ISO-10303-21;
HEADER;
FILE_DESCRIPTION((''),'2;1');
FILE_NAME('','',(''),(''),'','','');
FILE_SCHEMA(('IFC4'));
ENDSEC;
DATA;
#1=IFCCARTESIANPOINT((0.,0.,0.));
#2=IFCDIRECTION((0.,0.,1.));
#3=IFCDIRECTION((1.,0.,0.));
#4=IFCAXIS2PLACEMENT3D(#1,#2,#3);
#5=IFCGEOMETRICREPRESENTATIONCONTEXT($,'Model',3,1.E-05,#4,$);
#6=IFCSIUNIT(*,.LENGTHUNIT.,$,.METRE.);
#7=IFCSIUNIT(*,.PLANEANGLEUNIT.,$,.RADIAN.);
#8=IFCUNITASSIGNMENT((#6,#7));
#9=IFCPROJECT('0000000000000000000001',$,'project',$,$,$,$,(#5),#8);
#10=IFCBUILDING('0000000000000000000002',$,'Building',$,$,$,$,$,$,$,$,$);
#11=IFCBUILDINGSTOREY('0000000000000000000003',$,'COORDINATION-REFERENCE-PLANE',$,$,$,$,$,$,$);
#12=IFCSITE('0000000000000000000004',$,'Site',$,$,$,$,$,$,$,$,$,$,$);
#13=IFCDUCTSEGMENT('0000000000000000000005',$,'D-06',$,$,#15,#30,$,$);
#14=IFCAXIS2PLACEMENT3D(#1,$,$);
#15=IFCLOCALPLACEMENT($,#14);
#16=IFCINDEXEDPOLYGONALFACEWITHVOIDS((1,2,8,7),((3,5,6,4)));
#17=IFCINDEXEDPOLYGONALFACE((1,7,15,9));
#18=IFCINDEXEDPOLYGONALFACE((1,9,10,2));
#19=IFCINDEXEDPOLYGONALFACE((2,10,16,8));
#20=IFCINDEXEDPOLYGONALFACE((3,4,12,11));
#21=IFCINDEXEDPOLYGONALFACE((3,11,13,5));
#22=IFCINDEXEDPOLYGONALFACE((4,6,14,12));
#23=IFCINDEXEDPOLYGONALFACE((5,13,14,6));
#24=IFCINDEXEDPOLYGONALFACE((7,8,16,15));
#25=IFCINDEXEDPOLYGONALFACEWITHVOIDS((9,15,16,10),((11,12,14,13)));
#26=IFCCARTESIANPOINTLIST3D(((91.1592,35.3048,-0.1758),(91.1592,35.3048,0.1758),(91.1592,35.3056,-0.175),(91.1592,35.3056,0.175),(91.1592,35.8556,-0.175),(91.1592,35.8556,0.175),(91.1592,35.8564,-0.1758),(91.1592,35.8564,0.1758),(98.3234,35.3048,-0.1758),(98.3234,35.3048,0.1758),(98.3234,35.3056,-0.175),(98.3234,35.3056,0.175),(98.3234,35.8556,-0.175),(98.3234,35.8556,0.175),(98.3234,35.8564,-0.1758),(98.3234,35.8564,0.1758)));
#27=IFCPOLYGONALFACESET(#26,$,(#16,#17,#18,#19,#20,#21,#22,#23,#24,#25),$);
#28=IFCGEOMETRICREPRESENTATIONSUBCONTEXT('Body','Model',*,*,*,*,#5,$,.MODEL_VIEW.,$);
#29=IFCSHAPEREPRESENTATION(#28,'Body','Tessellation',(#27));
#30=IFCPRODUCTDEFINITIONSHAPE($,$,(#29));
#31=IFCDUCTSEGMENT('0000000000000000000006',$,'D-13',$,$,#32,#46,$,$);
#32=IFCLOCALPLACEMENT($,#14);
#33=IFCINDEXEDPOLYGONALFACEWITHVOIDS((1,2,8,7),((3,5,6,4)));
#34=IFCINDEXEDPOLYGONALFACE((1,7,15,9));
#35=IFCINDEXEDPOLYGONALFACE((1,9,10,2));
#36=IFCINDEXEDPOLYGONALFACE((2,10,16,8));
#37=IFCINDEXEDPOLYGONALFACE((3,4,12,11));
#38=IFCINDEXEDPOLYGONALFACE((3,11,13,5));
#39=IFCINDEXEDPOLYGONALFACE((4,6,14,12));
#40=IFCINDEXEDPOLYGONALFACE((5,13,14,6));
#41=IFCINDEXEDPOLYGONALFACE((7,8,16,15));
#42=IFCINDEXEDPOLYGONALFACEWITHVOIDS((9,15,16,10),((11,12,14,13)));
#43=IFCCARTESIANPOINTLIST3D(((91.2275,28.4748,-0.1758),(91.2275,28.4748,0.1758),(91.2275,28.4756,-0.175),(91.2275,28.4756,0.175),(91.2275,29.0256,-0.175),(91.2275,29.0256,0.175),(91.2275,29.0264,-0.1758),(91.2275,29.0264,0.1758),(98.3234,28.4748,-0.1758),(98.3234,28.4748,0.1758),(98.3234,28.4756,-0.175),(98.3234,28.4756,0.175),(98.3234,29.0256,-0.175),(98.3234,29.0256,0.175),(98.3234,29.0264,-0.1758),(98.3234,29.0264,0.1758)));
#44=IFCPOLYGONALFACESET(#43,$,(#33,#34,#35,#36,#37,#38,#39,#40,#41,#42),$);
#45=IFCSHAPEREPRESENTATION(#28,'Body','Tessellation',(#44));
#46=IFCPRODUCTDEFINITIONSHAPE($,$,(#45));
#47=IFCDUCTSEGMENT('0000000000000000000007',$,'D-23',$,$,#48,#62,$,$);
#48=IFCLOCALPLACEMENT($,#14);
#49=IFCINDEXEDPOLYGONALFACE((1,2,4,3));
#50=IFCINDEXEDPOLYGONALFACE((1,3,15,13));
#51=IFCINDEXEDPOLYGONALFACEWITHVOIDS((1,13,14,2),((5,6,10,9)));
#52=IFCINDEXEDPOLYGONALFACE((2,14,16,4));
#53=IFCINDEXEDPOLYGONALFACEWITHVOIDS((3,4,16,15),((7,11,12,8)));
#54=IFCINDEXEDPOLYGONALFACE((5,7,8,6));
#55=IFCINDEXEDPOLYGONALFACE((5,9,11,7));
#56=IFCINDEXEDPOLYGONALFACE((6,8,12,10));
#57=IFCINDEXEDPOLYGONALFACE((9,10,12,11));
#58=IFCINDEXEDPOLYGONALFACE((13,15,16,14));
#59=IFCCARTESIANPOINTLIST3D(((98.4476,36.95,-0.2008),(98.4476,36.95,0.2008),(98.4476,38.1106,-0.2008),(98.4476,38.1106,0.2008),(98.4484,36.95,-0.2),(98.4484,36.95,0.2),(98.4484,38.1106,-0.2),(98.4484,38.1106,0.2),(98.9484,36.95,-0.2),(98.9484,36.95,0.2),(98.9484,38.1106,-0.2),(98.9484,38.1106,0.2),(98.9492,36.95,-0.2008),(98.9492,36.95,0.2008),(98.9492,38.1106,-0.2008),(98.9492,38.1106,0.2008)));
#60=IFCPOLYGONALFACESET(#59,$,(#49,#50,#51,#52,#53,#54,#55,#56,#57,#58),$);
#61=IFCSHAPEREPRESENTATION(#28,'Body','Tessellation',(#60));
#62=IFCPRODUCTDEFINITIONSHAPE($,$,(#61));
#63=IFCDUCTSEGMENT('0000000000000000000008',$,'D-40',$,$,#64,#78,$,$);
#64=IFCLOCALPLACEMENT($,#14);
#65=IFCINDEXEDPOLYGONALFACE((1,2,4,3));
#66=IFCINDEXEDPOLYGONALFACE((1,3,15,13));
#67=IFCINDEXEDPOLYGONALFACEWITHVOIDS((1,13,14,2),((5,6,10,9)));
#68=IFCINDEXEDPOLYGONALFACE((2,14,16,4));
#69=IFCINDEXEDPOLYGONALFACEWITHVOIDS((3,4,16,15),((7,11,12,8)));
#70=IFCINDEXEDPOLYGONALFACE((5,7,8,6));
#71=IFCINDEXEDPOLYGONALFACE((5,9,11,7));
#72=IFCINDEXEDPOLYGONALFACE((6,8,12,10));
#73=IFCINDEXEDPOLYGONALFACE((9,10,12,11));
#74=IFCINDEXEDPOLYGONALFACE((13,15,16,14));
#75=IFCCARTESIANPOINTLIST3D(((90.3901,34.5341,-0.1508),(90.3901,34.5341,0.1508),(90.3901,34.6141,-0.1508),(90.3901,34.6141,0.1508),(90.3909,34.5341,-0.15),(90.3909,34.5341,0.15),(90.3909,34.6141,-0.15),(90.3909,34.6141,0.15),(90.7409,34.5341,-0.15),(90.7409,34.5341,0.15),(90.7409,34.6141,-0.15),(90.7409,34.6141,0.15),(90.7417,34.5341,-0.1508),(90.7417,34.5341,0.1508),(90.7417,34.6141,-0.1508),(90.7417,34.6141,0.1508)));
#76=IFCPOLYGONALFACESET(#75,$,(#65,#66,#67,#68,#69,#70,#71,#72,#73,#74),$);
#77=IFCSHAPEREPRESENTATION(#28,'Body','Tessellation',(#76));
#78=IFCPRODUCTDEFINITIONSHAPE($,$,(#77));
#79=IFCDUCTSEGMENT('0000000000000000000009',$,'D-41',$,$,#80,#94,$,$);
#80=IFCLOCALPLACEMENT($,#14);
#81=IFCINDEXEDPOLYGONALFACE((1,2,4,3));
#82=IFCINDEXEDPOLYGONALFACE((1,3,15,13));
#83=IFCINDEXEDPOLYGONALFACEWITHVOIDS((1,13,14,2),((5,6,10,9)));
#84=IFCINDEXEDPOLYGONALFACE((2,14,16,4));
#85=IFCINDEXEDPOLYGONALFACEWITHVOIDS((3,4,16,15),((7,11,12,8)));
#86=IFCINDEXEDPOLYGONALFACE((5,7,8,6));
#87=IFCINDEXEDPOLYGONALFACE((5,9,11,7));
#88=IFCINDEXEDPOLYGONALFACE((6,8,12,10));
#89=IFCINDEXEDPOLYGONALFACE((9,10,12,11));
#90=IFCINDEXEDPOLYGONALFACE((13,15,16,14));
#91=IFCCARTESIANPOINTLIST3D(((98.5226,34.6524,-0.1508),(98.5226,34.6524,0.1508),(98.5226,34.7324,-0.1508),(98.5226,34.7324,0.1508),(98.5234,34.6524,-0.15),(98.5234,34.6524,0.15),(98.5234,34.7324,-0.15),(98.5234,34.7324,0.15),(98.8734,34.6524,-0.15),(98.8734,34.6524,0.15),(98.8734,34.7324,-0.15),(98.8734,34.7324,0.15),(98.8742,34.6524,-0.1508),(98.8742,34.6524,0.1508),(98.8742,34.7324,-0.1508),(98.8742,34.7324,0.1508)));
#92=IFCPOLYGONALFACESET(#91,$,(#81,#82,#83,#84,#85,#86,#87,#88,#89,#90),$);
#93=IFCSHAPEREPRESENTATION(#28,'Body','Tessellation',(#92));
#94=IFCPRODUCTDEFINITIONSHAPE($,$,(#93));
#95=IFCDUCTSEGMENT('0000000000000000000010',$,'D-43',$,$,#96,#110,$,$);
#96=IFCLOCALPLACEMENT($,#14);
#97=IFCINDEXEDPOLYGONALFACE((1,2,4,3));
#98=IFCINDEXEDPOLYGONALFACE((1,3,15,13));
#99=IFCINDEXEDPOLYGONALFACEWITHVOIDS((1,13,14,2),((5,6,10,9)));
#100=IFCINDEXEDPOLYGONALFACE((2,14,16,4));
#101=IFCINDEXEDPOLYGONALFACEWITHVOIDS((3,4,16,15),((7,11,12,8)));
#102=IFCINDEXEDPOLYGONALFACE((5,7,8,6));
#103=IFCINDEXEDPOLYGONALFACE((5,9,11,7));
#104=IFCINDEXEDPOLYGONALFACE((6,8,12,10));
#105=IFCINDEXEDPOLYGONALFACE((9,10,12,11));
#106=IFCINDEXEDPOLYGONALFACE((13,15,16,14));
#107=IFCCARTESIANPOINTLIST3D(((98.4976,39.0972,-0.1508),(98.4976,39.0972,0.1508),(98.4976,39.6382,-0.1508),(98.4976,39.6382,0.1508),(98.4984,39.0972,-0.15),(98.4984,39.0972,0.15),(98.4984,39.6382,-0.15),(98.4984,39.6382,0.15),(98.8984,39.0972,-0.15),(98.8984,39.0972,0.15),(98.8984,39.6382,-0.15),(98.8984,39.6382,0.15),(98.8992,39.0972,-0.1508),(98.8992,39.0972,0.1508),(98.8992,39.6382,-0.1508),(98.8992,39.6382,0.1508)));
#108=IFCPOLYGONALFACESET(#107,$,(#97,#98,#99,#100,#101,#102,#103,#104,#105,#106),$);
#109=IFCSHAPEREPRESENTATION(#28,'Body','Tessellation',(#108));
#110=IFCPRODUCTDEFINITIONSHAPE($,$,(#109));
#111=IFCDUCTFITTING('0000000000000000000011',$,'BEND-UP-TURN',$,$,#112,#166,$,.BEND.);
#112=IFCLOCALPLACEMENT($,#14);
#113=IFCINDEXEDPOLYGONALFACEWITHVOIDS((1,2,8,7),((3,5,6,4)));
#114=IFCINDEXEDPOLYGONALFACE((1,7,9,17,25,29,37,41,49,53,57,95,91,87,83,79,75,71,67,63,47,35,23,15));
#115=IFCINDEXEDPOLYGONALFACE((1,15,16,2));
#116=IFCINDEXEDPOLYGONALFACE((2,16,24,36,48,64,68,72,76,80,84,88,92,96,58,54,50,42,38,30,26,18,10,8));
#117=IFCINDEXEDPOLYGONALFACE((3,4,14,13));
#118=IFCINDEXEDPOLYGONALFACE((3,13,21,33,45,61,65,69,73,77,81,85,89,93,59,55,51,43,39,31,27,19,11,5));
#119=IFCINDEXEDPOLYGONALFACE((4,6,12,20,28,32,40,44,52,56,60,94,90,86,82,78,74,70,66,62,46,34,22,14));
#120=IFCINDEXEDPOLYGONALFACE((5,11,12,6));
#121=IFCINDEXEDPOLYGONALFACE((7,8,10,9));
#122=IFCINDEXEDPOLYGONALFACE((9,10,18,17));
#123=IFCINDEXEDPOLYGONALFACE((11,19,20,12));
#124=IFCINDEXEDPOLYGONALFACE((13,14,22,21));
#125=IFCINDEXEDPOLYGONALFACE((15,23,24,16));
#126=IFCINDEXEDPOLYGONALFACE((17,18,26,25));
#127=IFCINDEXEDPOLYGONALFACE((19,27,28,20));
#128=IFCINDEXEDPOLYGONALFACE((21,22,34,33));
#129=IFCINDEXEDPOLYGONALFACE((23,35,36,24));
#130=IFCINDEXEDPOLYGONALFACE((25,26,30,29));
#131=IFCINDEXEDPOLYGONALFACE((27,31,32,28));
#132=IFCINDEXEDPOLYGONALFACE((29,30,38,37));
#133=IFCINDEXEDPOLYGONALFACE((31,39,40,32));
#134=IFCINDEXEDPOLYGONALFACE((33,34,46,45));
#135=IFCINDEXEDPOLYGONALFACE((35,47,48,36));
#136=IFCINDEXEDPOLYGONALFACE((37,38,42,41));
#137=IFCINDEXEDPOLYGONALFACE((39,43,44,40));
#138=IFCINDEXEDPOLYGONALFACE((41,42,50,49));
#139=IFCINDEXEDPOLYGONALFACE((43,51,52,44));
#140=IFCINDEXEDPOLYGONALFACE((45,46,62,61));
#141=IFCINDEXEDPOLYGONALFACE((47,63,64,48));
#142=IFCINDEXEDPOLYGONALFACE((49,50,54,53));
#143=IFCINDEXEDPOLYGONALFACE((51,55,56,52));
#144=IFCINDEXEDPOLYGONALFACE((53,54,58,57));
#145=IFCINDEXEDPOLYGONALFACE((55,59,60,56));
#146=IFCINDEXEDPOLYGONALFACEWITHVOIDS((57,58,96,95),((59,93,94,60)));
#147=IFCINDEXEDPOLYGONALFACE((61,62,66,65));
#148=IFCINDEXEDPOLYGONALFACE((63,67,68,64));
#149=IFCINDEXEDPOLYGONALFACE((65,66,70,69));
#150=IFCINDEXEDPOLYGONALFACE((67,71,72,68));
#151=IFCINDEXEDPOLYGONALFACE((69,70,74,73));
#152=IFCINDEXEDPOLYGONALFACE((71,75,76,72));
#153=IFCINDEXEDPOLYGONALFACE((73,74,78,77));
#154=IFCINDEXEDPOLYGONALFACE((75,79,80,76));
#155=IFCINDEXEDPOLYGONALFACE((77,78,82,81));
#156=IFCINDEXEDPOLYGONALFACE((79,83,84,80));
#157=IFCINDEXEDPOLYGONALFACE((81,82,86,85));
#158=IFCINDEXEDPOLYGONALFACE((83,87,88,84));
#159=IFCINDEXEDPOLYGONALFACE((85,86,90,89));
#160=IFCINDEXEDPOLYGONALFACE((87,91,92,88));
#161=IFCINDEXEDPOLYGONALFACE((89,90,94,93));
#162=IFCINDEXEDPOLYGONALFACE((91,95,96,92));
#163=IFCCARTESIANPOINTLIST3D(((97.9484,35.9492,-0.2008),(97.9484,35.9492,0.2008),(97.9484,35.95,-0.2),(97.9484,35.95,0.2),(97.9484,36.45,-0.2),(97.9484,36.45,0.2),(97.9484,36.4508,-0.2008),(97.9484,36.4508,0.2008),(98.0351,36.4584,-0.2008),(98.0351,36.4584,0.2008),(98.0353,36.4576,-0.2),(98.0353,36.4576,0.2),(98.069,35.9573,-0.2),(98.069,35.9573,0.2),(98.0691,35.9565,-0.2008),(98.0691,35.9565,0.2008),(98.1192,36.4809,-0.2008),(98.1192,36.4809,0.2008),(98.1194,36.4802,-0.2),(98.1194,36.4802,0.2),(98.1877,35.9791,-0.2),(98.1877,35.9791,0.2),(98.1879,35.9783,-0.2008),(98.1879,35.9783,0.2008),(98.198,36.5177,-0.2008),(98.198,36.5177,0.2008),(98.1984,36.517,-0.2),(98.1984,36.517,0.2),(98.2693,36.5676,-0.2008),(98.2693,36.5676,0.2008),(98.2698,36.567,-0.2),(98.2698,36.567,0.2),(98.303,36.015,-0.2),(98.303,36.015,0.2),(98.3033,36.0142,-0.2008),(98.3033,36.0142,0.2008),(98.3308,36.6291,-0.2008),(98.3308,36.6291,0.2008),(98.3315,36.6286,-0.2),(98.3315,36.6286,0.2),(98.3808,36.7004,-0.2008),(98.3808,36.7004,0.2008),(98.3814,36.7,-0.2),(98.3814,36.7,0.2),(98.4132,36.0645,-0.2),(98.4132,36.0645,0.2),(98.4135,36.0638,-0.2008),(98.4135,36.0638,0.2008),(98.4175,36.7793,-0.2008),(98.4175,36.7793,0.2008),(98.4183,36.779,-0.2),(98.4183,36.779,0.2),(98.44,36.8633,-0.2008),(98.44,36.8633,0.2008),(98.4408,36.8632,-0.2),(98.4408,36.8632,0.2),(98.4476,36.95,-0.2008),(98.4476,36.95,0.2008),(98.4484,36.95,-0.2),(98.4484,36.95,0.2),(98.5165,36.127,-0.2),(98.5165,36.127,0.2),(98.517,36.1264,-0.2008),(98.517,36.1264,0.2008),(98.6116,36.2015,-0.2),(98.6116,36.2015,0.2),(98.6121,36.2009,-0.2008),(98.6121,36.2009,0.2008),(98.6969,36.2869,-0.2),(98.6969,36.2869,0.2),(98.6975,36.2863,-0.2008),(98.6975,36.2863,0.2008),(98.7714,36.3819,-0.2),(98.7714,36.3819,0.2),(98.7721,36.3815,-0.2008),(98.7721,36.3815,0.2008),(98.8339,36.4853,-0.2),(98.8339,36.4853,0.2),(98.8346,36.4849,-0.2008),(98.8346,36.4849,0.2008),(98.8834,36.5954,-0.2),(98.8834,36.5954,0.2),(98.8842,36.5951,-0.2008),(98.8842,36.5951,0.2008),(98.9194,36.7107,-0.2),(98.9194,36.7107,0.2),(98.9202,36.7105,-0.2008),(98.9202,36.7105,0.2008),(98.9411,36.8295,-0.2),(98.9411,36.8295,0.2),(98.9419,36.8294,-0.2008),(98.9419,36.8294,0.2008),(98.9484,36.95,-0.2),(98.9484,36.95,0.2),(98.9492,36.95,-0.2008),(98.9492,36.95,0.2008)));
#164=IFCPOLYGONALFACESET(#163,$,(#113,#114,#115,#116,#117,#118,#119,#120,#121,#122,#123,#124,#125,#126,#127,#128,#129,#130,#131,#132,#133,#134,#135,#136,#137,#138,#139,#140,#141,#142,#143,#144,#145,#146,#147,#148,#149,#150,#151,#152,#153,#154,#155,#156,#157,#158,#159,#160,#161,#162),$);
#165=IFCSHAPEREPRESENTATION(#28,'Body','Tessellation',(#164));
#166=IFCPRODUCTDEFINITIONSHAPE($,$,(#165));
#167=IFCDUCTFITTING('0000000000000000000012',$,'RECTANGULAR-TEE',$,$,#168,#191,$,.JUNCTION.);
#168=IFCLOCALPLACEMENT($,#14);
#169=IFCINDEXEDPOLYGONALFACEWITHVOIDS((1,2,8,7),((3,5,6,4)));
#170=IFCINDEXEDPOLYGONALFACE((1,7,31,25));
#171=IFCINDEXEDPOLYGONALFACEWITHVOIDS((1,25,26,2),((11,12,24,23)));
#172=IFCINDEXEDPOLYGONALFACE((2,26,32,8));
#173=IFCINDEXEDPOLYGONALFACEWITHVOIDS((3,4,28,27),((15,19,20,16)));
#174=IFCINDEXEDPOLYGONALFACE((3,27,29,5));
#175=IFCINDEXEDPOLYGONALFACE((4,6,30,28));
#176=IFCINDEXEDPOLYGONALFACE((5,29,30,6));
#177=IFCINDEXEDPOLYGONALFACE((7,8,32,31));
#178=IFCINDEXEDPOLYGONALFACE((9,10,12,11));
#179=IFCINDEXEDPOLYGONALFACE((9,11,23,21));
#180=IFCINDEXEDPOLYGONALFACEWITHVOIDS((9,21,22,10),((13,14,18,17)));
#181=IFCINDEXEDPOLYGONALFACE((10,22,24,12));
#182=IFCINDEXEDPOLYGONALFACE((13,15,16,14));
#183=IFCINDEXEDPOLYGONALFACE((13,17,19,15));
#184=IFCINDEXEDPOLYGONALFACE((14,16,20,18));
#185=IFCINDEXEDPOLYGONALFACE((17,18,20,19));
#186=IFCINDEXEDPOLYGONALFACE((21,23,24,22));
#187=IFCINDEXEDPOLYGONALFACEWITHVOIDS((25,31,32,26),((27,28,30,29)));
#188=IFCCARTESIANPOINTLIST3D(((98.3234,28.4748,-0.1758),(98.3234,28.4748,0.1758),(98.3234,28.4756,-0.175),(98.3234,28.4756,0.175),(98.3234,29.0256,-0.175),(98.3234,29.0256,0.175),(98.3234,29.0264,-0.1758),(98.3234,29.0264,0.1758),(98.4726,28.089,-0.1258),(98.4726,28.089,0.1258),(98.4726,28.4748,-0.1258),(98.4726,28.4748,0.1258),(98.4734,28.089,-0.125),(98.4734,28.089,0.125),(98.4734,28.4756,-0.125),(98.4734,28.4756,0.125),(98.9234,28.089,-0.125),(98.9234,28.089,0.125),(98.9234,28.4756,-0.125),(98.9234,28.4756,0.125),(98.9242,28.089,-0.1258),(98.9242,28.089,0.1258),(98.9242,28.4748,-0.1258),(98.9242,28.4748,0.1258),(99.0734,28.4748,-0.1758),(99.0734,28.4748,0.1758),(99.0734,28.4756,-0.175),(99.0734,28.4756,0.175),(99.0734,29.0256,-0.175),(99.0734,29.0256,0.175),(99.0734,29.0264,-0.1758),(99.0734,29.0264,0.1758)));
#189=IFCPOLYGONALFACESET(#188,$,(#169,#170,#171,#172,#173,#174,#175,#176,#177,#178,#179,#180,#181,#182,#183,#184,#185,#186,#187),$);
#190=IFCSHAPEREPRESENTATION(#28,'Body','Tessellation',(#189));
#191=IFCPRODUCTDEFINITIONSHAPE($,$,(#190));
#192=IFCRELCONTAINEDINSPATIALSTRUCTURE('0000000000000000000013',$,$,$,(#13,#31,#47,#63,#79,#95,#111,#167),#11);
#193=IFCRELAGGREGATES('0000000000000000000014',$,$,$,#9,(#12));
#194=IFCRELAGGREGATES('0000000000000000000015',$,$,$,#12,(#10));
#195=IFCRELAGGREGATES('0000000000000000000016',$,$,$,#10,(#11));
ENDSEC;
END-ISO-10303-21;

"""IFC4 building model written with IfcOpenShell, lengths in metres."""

from ifc_helpers import new_model, entity, si_unit, frame, origin, origin_with_axes, place, context, subcontext, project, spatial, rectangle, hollow_rectangle, extrude, boolean, element, save


model = new_model("IFC4")

# Units and contexts
model_context = context("Model", 3, precision=1e-05, world=origin_with_axes())
body_context_1 = subcontext(model_context, "Body", "Model", "MODEL_VIEW")
ifc_project = project(units=[si_unit("LENGTHUNIT", "METRE"), si_unit("PLANEANGLEUNIT", "RADIAN")], contexts=[model_context])

# Site, building, storey
site = spatial("IfcSite", under=ifc_project, Name="Site")
building = spatial("IfcBuilding", under=site, Name="Building")
storey = spatial("IfcBuildingStorey", under=building, Name="COORDINATION-REFERENCE-PLANE")

# Duct segments
duct_segment_1_placement = place(None, frame((91.1592, 35.5806, 0.0), z_axis=(1.0, 0.0, 0.0), x_axis=(0.0, 1.0, 0.0)))
element("IfcDuctSegment", 1, at=duct_segment_1_placement, inside=storey, Name="D-06", context=body_context_1, shape_type="SweptSolid", body=[
    extrude(hollow_rectangle(XDim=0.5516, YDim=0.3516, WallThickness=0.0008), origin(), (0.0, 0.0, 1.0), 7.1642),
])
duct_segment_2_placement = place(None, frame((91.2275, 28.7506, 0.0), z_axis=(1.0, 0.0, 0.0), x_axis=(0.0, 1.0, 0.0)))
element("IfcDuctSegment", 2, at=duct_segment_2_placement, inside=storey, Name="D-13", context=body_context_1, shape_type="SweptSolid", body=[
    extrude(hollow_rectangle(XDim=0.5516, YDim=0.3516, WallThickness=0.0008), origin(), (0.0, 0.0, 1.0), 7.0959),
])
duct_segment_3_placement = place(None, frame((98.6984, 36.95, 0.0), z_axis=(0.0, 1.0, 0.0), x_axis=(1.0, 0.0, 0.0)))
element("IfcDuctSegment", 3, at=duct_segment_3_placement, inside=storey, Name="D-23", context=body_context_1, shape_type="SweptSolid", body=[
    extrude(hollow_rectangle(XDim=0.5016, YDim=0.4016, WallThickness=0.0008), origin(), (0.0, 0.0, 1.0), 1.1606),
])
for number, where, z_axis, x_axis, name in (
    (4, (90.5659, 34.5341, 0.0), (0.0, 1.0, 0.0), (1.0, 0.0, 0.0), "D-40"),
    (5, (98.6984, 34.6524, 0.0), (0.0, 1.0, 0.0), (1.0, 0.0, 0.0), "D-41"),
):
    element("IfcDuctSegment", number, at=place(None, frame(where, z_axis=z_axis, x_axis=x_axis)), inside=storey, Name=name, context=body_context_1, shape_type="SweptSolid", body=[
        extrude(hollow_rectangle(XDim=0.3516, YDim=0.3016, WallThickness=0.0008), origin(), (0.0, 0.0, 1.0), 0.08),
    ])
duct_segment_4_placement = place(None, frame((98.6984, 39.0972, 0.0), z_axis=(0.0, 1.0, 0.0), x_axis=(1.0, 0.0, 0.0)))
element("IfcDuctSegment", 6, at=duct_segment_4_placement, inside=storey, Name="D-43", context=body_context_1, shape_type="SweptSolid", body=[
    extrude(hollow_rectangle(XDim=0.4016, YDim=0.3016, WallThickness=0.0008), origin(), (0.0, 0.0, 1.0), 0.541),
])

# Duct fittings
duct_fitting_1_placement = place(None, frame((97.9484, 36.95, 0.0), z_axis=(0.0, 0.0, 1.0), x_axis=(0.0, -1.0, 0.0)))
cartesian_point = entity("IfcCartesianPoint", [0.0, 0.0, 0.0])
element("IfcDuctFitting", 7, at=duct_fitting_1_placement, inside=storey, Name="BEND-UP-TURN", PredefinedType="BEND", context=body_context_1, shape_type="SweptSolid", body=[
    entity("IfcRevolvedAreaSolid", entity("IfcRectangleHollowProfileDef", "AREA", None, entity("IfcAxis2Placement2D", entity("IfcCartesianPoint", [0.75, 0.0])), 0.5016, 0.4016, 0.0008), entity("IfcAxis2Placement3D", cartesian_point, entity("IfcDirection", [0.0, -1.0, 0.0]), entity("IfcDirection", [1.0, 0.0, 0.0])), entity("IfcAxis1Placement", cartesian_point, entity("IfcDirection", [0.0, 1.0, 0.0])), 1.570796),
])
duct_fitting_2_placement = place(None, frame((98.6984, 28.7506, 0.0), z_axis=(1.0, 0.0, 0.0), x_axis=(0.0, -1.0, 0.0)))
solid_1 = boolean("UNION", extrude(rectangle(XDim=0.55, YDim=0.35), frame((0.0, 0.0, -0.375), z_axis=(0.0, 0.0, 1.0), x_axis=(1.0, 0.0, 0.0)), (0.0, 0.0, 1.0), 0.75), extrude(rectangle(XDim=0.45, YDim=0.25), frame((0.0, 0.0, 0.0), z_axis=(1.0, 0.0, 0.0), x_axis=(0.0, 0.0, -1.0)), (0.0, 0.0, 1.0), 0.6616))
element("IfcDuctFitting", 8, at=duct_fitting_2_placement, inside=storey, Name="RECTANGULAR-TEE", PredefinedType="JUNCTION", context=body_context_1, shape_type="CSG", body=[
    boolean("DIFFERENCE", boolean("UNION", extrude(rectangle(XDim=0.5516, YDim=0.3516), frame((0.0, 0.0, -0.375), z_axis=(0.0, 0.0, 1.0), x_axis=(1.0, 0.0, 0.0)), (0.0, 0.0, 1.0), 0.75), extrude(rectangle(XDim=0.4516, YDim=0.2516), frame((0.0, 0.0, 0.0), z_axis=(1.0, 0.0, 0.0), x_axis=(0.0, 0.0, -1.0)), (0.0, 0.0, 1.0), 0.6616)), solid_1),
])

save(model, "model.ifc")
